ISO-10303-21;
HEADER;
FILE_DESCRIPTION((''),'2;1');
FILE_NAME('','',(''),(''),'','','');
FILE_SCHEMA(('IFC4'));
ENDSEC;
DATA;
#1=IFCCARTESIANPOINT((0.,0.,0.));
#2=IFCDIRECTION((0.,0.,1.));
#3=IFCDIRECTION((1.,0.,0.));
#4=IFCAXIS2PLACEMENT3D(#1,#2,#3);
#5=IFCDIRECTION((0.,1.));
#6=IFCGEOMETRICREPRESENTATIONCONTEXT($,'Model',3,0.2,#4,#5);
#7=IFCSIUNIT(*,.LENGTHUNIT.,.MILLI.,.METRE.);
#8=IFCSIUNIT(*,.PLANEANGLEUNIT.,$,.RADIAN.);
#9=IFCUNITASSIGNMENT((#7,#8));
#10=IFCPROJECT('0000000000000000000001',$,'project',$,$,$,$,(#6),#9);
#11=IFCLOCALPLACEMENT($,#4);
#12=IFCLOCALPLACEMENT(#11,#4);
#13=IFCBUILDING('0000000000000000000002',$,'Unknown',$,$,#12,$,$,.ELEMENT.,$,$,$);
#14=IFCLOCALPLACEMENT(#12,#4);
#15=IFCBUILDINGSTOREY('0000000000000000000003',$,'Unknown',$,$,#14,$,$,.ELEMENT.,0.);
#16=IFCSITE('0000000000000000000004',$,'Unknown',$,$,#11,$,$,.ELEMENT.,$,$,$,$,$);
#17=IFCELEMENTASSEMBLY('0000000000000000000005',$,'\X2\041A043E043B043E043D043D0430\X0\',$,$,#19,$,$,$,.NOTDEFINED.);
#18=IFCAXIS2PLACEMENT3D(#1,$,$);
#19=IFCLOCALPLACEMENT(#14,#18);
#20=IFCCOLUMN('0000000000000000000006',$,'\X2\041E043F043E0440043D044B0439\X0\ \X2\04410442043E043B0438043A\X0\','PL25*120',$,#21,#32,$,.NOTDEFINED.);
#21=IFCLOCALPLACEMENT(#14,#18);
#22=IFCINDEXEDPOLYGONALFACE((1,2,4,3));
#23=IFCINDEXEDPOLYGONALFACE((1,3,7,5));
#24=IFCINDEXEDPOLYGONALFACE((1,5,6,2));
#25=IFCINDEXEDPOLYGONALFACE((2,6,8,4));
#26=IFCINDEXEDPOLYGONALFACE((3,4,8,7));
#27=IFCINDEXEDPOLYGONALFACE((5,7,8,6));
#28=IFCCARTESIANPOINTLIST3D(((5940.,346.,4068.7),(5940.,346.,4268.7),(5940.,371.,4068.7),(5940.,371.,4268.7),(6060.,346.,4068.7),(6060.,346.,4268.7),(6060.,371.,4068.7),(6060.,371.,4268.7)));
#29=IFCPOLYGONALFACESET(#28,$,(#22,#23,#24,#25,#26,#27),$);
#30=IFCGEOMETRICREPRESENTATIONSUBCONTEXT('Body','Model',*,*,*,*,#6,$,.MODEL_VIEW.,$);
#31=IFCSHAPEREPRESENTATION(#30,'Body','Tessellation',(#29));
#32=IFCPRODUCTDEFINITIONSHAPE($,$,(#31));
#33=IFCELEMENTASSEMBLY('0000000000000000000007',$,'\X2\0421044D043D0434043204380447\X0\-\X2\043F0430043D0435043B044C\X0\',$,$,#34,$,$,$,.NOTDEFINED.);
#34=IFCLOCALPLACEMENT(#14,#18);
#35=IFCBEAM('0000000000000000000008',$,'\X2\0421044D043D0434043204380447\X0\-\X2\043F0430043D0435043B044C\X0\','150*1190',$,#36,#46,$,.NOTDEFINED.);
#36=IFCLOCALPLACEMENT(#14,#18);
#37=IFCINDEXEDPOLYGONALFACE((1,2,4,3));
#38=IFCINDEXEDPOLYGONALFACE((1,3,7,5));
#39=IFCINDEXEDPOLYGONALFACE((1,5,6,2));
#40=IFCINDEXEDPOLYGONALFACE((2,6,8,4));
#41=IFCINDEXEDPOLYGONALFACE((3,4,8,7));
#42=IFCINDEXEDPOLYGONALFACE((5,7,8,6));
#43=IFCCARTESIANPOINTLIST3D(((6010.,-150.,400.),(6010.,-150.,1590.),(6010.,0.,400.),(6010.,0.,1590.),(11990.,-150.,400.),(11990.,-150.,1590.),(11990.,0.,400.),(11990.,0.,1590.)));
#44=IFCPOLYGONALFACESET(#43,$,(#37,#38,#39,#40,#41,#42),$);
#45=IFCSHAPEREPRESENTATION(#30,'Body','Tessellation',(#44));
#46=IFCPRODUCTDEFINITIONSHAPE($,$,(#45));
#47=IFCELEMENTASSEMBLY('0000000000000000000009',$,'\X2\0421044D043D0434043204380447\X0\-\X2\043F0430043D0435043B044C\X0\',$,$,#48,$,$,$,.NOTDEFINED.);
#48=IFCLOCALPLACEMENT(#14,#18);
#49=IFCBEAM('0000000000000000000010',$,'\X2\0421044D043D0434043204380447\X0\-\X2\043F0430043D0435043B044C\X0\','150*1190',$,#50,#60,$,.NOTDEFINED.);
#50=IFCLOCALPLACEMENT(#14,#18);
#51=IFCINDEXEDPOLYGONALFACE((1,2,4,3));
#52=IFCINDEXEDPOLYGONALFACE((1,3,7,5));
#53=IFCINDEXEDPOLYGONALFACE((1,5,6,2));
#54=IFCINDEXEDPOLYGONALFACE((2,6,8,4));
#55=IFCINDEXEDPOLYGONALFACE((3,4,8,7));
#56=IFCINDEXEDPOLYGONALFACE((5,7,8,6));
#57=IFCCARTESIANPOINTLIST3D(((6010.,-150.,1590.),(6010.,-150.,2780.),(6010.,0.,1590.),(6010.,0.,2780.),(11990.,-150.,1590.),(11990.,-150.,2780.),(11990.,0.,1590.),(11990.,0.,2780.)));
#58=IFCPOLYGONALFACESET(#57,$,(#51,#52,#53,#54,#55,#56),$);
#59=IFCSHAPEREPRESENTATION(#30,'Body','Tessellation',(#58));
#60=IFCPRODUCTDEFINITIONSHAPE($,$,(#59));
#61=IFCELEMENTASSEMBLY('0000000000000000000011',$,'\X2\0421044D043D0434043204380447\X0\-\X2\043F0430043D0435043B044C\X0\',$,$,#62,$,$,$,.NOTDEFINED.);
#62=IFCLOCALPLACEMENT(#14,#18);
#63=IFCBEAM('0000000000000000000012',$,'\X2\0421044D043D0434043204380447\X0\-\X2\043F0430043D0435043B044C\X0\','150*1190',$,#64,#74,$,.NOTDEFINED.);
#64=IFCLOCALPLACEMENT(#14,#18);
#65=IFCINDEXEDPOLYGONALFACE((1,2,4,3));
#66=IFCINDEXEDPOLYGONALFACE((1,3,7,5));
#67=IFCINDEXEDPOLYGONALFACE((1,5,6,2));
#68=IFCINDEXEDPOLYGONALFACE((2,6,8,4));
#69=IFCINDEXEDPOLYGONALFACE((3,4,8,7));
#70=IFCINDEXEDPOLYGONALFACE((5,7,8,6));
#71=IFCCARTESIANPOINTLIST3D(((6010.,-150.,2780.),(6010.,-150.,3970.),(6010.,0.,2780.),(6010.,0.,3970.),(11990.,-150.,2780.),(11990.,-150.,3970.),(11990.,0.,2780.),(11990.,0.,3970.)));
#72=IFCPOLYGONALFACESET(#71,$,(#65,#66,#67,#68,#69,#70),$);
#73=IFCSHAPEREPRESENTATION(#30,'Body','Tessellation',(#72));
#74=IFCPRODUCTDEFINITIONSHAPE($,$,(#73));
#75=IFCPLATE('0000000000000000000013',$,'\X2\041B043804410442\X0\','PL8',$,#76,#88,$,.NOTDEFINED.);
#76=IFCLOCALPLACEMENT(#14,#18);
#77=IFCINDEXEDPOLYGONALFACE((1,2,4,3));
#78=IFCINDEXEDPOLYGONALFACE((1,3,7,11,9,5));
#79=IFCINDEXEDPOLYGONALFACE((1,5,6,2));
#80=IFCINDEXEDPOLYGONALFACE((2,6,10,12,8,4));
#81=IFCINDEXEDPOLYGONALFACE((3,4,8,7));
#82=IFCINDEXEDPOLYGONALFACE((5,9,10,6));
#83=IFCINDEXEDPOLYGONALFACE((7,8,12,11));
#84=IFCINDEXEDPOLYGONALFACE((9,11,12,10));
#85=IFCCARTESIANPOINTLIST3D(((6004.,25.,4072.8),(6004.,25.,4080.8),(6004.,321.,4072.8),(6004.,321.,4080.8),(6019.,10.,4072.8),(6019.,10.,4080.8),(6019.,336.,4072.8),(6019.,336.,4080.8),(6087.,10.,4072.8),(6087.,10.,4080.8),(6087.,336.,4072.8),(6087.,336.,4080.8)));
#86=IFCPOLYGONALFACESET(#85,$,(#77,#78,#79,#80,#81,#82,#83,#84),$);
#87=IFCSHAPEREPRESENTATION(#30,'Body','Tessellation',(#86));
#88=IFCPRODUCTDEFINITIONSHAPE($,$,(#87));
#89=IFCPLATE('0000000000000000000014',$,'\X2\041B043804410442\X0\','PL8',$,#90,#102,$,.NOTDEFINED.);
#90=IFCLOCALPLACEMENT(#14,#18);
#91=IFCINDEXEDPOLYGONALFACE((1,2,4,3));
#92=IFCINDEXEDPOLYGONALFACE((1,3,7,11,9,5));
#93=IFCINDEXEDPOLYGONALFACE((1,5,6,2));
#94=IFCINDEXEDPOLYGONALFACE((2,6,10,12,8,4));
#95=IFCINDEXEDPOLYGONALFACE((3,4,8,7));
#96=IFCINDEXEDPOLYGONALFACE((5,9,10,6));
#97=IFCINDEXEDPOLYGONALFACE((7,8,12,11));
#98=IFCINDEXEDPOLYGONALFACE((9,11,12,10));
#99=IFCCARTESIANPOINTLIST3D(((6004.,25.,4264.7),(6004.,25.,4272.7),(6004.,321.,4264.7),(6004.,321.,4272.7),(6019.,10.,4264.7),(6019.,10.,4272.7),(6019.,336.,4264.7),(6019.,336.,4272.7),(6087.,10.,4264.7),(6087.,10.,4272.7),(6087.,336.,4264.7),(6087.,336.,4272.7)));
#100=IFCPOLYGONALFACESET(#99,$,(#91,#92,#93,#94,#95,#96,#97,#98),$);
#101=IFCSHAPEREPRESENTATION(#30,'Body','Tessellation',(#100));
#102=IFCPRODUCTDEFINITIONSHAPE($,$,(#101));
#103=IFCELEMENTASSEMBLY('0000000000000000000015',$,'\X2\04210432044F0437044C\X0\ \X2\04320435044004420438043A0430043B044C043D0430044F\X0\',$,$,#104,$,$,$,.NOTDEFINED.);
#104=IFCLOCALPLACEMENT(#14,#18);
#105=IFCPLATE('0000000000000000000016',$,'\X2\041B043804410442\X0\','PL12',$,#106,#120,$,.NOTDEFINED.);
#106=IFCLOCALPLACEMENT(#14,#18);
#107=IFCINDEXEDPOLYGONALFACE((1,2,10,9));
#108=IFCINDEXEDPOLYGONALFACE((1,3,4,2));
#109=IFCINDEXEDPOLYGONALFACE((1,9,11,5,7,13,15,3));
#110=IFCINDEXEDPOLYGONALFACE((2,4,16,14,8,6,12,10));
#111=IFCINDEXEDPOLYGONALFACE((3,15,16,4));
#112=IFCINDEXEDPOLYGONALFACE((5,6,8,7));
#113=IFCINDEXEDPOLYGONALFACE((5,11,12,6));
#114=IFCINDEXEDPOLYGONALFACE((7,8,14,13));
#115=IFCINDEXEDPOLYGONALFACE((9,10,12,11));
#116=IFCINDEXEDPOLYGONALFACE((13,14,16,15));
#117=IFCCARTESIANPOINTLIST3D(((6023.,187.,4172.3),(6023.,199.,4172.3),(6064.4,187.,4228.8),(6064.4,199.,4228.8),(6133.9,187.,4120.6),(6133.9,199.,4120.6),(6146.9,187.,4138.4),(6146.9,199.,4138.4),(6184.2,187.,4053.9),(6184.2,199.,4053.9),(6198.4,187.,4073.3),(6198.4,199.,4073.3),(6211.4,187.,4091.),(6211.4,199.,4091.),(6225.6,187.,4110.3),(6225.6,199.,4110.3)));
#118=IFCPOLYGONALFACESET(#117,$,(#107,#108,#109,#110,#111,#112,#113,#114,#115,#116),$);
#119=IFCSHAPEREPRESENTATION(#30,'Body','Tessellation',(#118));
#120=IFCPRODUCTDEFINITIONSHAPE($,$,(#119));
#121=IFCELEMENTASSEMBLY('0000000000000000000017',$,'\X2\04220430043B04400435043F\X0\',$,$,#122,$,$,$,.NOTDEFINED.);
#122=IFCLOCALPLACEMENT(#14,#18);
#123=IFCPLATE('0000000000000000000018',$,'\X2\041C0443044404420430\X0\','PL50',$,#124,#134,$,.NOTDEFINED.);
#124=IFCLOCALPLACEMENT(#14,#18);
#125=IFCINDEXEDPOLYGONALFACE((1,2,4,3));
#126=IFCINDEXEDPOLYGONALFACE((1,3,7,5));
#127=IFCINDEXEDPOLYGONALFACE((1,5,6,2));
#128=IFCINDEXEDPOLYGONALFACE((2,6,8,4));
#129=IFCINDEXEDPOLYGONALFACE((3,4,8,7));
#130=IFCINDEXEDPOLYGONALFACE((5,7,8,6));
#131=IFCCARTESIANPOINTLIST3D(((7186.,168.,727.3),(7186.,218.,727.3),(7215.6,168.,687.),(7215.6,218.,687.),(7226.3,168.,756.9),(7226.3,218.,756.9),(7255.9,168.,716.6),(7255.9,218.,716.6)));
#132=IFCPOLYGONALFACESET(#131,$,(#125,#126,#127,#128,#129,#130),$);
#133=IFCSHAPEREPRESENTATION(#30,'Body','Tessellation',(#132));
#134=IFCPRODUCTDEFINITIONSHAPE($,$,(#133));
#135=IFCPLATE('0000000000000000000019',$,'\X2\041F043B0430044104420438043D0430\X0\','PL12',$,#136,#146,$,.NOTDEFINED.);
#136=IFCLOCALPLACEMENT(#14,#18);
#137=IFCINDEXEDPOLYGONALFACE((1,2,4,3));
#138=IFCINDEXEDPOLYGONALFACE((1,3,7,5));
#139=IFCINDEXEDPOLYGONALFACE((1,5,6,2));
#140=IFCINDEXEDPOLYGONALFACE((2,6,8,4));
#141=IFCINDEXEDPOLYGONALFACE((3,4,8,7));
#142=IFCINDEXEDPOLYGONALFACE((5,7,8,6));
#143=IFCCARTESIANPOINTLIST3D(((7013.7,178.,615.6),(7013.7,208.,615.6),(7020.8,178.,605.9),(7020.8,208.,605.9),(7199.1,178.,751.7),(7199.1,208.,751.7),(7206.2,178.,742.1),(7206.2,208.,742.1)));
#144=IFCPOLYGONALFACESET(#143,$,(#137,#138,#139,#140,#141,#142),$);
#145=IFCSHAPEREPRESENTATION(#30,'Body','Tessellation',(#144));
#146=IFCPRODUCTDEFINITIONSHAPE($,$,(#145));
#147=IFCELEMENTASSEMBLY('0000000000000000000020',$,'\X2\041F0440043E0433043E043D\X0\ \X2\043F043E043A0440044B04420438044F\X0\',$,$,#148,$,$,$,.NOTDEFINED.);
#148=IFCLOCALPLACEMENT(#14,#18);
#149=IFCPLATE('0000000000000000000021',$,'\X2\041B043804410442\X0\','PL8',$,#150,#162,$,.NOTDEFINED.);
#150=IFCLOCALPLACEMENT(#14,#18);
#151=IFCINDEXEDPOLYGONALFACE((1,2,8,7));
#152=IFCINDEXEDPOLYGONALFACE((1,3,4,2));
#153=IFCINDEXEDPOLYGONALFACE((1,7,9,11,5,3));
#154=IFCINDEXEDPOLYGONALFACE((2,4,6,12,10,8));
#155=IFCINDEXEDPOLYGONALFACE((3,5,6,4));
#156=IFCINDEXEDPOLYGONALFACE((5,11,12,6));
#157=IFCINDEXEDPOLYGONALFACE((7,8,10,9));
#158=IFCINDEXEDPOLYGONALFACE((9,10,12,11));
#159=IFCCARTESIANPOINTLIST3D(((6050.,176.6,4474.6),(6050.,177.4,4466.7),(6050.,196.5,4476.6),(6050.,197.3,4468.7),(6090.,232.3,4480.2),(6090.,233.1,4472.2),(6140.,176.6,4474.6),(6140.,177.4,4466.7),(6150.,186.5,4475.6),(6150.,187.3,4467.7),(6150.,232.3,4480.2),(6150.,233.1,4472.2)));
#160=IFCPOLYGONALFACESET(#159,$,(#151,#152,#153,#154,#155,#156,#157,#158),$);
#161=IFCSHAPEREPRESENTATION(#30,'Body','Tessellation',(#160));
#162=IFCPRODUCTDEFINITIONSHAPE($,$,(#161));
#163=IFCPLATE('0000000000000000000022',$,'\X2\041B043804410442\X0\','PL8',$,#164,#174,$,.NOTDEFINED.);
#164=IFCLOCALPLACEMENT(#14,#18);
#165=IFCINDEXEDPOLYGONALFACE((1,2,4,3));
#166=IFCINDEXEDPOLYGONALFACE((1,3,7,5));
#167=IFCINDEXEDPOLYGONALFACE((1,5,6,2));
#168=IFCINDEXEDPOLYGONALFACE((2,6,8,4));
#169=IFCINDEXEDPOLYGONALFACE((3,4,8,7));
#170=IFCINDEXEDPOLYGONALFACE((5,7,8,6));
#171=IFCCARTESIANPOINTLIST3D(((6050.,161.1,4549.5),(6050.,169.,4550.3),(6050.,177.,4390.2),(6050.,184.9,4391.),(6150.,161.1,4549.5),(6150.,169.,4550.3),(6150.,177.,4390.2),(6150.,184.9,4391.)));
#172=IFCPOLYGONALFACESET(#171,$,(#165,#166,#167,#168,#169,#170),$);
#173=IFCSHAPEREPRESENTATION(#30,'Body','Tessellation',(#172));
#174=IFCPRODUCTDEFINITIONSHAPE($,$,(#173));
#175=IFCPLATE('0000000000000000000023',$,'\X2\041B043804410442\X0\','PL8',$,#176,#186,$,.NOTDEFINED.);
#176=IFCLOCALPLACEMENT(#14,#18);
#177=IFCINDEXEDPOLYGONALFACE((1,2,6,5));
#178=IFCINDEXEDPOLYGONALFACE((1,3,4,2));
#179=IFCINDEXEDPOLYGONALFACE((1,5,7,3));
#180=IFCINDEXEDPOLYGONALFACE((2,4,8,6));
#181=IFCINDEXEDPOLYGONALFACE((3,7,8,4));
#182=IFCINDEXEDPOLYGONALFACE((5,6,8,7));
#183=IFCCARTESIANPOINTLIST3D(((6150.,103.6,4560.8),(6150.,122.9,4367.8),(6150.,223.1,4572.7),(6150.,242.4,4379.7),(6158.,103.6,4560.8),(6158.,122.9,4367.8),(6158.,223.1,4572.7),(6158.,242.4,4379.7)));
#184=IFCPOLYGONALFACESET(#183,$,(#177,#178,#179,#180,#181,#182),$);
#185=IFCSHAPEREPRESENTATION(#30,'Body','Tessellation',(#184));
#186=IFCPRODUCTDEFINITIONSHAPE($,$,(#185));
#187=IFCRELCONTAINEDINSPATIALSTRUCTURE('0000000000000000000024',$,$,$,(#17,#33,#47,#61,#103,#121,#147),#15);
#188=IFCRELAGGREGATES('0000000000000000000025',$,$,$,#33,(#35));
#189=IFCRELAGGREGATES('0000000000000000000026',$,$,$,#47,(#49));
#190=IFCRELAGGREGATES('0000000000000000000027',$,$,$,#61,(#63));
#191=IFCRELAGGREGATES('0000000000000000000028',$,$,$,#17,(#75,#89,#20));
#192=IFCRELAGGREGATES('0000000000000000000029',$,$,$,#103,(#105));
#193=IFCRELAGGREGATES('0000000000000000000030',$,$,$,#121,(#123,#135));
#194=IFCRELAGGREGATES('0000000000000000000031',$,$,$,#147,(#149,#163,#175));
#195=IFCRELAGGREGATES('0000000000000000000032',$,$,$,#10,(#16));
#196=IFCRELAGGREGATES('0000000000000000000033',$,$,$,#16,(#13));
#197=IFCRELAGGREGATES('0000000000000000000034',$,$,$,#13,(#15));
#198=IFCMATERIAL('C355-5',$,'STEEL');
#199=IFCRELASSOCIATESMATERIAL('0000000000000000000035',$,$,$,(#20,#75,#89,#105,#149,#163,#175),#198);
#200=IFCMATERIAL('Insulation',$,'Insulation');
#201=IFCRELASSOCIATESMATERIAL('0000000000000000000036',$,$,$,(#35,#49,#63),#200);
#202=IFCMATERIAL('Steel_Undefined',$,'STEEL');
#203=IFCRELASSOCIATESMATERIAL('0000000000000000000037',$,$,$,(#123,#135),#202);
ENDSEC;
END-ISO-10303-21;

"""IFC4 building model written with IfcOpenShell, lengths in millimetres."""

from ifc_helpers import new_model, si_unit, direction, frame, origin_with_axes, place, context, subcontext, project, spatial, line, indexed_curve, outline, extrude, material, element, aggregate, save


model = new_model("IFC4")

# Units and contexts
model_context = context("Model", 3, precision=0.2, world=origin_with_axes(), true_north=direction((0.0, 1.0)))
body_context = subcontext(model_context, "Body", "Model", "MODEL_VIEW")
ifc_project = project(units=[si_unit("LENGTHUNIT", "METRE", prefix="MILLI"), si_unit("PLANEANGLEUNIT", "RADIAN")], contexts=[model_context])

# Site, building, storey
site_placement = place(None, origin_with_axes())
site = spatial("IfcSite", under=ifc_project, at=site_placement, Name="Unknown", CompositionType="ELEMENT")
building_placement = place(site_placement, origin_with_axes())
building = spatial("IfcBuilding", under=site, at=building_placement, Name="Unknown", CompositionType="ELEMENT")
storey_placement = place(building_placement, origin_with_axes())
storey = spatial("IfcBuildingStorey", under=building, at=storey_placement, Name="Unknown", CompositionType="ELEMENT", Elevation=0.0)

# Element assembly, column
assembly_1_placement = place(storey_placement, frame((6000.0, 173.0, -200.0), z_axis=(-1.0, 0.0, 0.0), x_axis=(0.0, 0.0, 1.0)))
assembly_1 = element("IfcElementAssembly", 1, at=assembly_1_placement, inside=storey, Name="Колонна", PredefinedType="NOTDEFINED")
ifc_material_1 = material(Name="C355-5", Category="STEEL")
column_1_placement = place(assembly_1_placement, frame((4268.7, 185.5, 0.0), z_axis=(0.0, 1.0, 0.0), x_axis=(1.0, 0.0, 0.0)))
column_1 = element("IfcColumn", 2, at=column_1_placement, material=ifc_material_1, Name="Опорный столик", Description="PL25*120", PredefinedType="NOTDEFINED", context=body_context, shape_type="SolidModel", body=[
    extrude(outline(indexed_curve([(-12.5, -60.0), (12.5, -60.0), (12.5, 60.0), (-12.5, 60.0)], segments=[line(1, 2, 3, 4, 1)])), frame((0.0, 0.0, 0.0), z_axis=(-1.0, 0.0, 0.0), x_axis=(0.0, 0.0, 1.0)), (0.0, 0.0, -1.0), 200.0),
])

# Element assemblies, beams
ifc_material_2 = material(Name="Insulation", Category="Insulation")
assembly_2_placement = place(storey_placement, frame((6010.0, -75.0, 995.0), z_axis=(0.0, 0.0, -1.0), x_axis=(1.0, 0.0, 0.0)))
assembly_2 = element("IfcElementAssembly", 3, at=assembly_2_placement, inside=storey, Name="Сэндвич-панель", PredefinedType="NOTDEFINED")
beam_1_placement = place(assembly_2_placement, origin_with_axes())
beam_1 = element("IfcBeam", 4, at=beam_1_placement, material=ifc_material_2, Name="Сэндвич-панель", Description="150*1190", PredefinedType="NOTDEFINED", context=body_context, shape_type="SolidModel", body=[
    extrude(outline(indexed_curve([(-595.0, -75.0), (595.0, -75.0), (595.0, 75.0), (-595.0, 75.0)], segments=[line(1, 2, 3, 4, 1)])), frame((0.0, 0.0, 0.0), z_axis=(-1.0, 0.0, 0.0), x_axis=(0.0, 0.0, 1.0)), (0.0, 0.0, -1.0), 5980.0),
])
aggregate(assembly_2, [beam_1])
assembly_3_placement = place(storey_placement, frame((6010.0, -75.0, 2185.0), z_axis=(0.0, 0.0, -1.0), x_axis=(1.0, 0.0, 0.0)))
assembly_3 = element("IfcElementAssembly", 5, at=assembly_3_placement, inside=storey, Name="Сэндвич-панель", PredefinedType="NOTDEFINED")
beam_2_placement = place(assembly_3_placement, origin_with_axes())
beam_2 = element("IfcBeam", 6, at=beam_2_placement, material=ifc_material_2, Name="Сэндвич-панель", Description="150*1190", PredefinedType="NOTDEFINED", context=body_context, shape_type="SolidModel", body=[
    extrude(outline(indexed_curve([(-595.0, -75.0), (595.0, -75.0), (595.0, 75.0), (-595.0, 75.0)], segments=[line(1, 2, 3, 4, 1)])), frame((0.0, 0.0, 0.0), z_axis=(-1.0, 0.0, 0.0), x_axis=(0.0, 0.0, 1.0)), (0.0, 0.0, -1.0), 5980.0),
])
aggregate(assembly_3, [beam_2])
assembly_4_placement = place(storey_placement, frame((6010.0, -75.0, 3375.0), z_axis=(0.0, 0.0, -1.0), x_axis=(1.0, 0.0, 0.0)))
assembly_4 = element("IfcElementAssembly", 7, at=assembly_4_placement, inside=storey, Name="Сэндвич-панель", PredefinedType="NOTDEFINED")
beam_3_placement = place(assembly_4_placement, origin_with_axes())
beam_3 = element("IfcBeam", 8, at=beam_3_placement, material=ifc_material_2, Name="Сэндвич-панель", Description="150*1190", PredefinedType="NOTDEFINED", context=body_context, shape_type="SolidModel", body=[
    extrude(outline(indexed_curve([(-595.0, -75.0), (595.0, -75.0), (595.0, 75.0), (-595.0, 75.0)], segments=[line(1, 2, 3, 4, 1)])), frame((0.0, 0.0, 0.0), z_axis=(-1.0, 0.0, 0.0), x_axis=(0.0, 0.0, 1.0)), (0.0, 0.0, -1.0), 5980.0),
])
aggregate(assembly_4, [beam_3])

# Plates
plate_1_placement = place(assembly_1_placement, frame((4276.8, -163.0, -87.0), z_axis=(-1.0, 0.0, 0.0), x_axis=(0.0, 0.0, 1.0)))
plate_1 = element("IfcPlate", 9, at=plate_1_placement, material=ifc_material_1, Name="Лист", Description="PL8", PredefinedType="NOTDEFINED", context=body_context, shape_type="SolidModel", body=[
    extrude(outline(indexed_curve([(0.0, 0.0), (68.0, 0.0), (83.0, 15.0), (83.0, 311.0), (68.0, 326.0), (0.0, 326.0)], segments=[line(1, 2, 3, 4, 5, 6, 1)])), frame((0.0, 0.0, 4.0), z_axis=(0.0, 0.0, 1.0), x_axis=(1.0, 0.0, 0.0)), (0.0, 0.0, -1.0), 8.0),
])
plate_2_placement = place(assembly_1_placement, frame((4468.7, -163.0, -87.0), z_axis=(-1.0, 0.0, 0.0), x_axis=(0.0, 0.0, 1.0)))
plate_2 = element("IfcPlate", 10, at=plate_2_placement, material=ifc_material_1, Name="Лист", Description="PL8", PredefinedType="NOTDEFINED", context=body_context, shape_type="SolidModel", body=[
    extrude(outline(indexed_curve([(0.0, 0.0), (68.0, 0.0), (83.0, 15.0), (83.0, 311.0), (68.0, 326.0), (0.0, 326.0)], segments=[line(1, 2, 3, 4, 5, 6, 1)])), frame((0.0, 0.0, 4.0), z_axis=(0.0, 0.0, 1.0), x_axis=(1.0, 0.0, 0.0)), (0.0, 0.0, -1.0), 8.0),
])
aggregate(assembly_1, [plate_1, plate_2, column_1])

# Element assembly, plate
assembly_5_placement = place(storey_placement, frame((6087.0, 193.0, 4168.8), z_axis=(0.0, -1.0, 0.0), x_axis=(0.805914, 0.0, -0.592033)))
assembly_5 = element("IfcElementAssembly", 11, at=assembly_5_placement, inside=storey, Name="Связь вертикальная", PredefinedType="NOTDEFINED")
plate_3_placement = place(assembly_5_placement, frame((146.3, -35.0, 0.0), z_axis=(0.0, 0.0, -1.0), x_axis=(-1.0, 0.0, 0.0)))
plate_3 = element("IfcPlate", 12, at=plate_3_placement, material=ifc_material_1, Name="Лист", Description="PL12", PredefinedType="NOTDEFINED", context=body_context, shape_type="SolidModel", body=[
    extrude(outline(indexed_curve([(0.0, 0.0), (200.0, 0.0), (200.0, 70.0), (0.0, 70.0), (0.0, 46.0), (80.0, 46.0), (80.0, 24.0), (0.0, 24.0)], segments=[line(1, 2, 3, 4, 5, 6, 7, 8, 1)])), frame((0.0, 0.0, 6.0), z_axis=(0.0, 0.0, 1.0), x_axis=(1.0, 0.0, 0.0)), (0.0, 0.0, -1.0), 12.0),
])
aggregate(assembly_5, [plate_3])

# Element assemblies, plates
assembly_6_placement = place(storey_placement, frame((7206.2, 168.0, 742.1), z_axis=(-0.805914, 0.0, -0.592033), x_axis=(0.0, 1.0, 0.0)))
assembly_6 = element("IfcElementAssembly", 13, at=assembly_6_placement, inside=storey, Name="Талреп", PredefinedType="NOTDEFINED")
ifc_material_3 = material(Name="Steel_Undefined", Category="STEEL")
plate_4_placement = place(assembly_6_placement, origin_with_axes())
plate_4 = element("IfcPlate", 14, at=plate_4_placement, material=ifc_material_3, Name="Муфта", Description="PL50", PredefinedType="NOTDEFINED", context=body_context, shape_type="SolidModel", body=[
    extrude(outline(indexed_curve([(0.0, 0.0), (50.0, 0.0), (50.0, 50.0), (0.0, 50.0)], segments=[line(1, 2, 3, 4, 1)])), frame((0.0, 0.0, 25.0), z_axis=(0.0, 0.0, 1.0), x_axis=(1.0, 0.0, 0.0)), (0.0, 0.0, -1.0), 50.0),
])
plate_5_placement = place(assembly_6_placement, frame((10.0, -6.0, 230.0), z_axis=(0.0, 1.0, 0.0), x_axis=(1.0, 0.0, 0.0)))
plate_5 = element("IfcPlate", 15, at=plate_5_placement, material=ifc_material_3, Name="Пластина", Description="PL12", PredefinedType="NOTDEFINED", context=body_context, shape_type="SolidModel", body=[
    extrude(outline(indexed_curve([(0.0, 0.0), (30.0, 0.0), (30.0, 230.0), (0.0, 230.0)], segments=[line(1, 2, 3, 4, 1)])), frame((0.0, 0.0, 6.0), z_axis=(0.0, 0.0, 1.0), x_axis=(1.0, 0.0, 0.0)), (0.0, 0.0, -1.0), 12.0),
])
aggregate(assembly_6, [plate_4, plate_5])
assembly_7_placement = place(storey_placement, frame((6000.0, 173.0, 4470.2), z_axis=(0.0, 0.995037, 0.099504), x_axis=(1.0, 0.0, 0.0)))
assembly_7 = element("IfcElementAssembly", 16, at=assembly_7_placement, inside=storey, Name="Прогон покрытия", PredefinedType="NOTDEFINED")
plate_6_placement = place(assembly_7_placement, frame((50.0, 0.0, 60.0), z_axis=(0.0, -1.0, 0.0), x_axis=(0.0, 0.0, -1.0)))
plate_6 = element("IfcPlate", 17, at=plate_6_placement, material=ifc_material_1, Name="Лист", Description="PL8", PredefinedType="NOTDEFINED", context=body_context, shape_type="SolidModel", body=[
    extrude(outline(indexed_curve([(0.0, 40.0), (36.0, 0.0), (56.0, 0.0), (56.0, 90.0), (46.0, 100.0), (0.0, 100.0)], segments=[line(1, 2, 3, 4, 5, 6, 1)])), frame((0.0, 0.0, 4.0), z_axis=(0.0, 0.0, 1.0), x_axis=(1.0, 0.0, 0.0)), (0.0, 0.0, -1.0), 8.0),
])
plate_7_placement = place(assembly_7_placement, frame((50.0, -80.0, 0.0), z_axis=(0.0, 0.0, -1.0), x_axis=(0.0, 1.0, 0.0)))
plate_7 = element("IfcPlate", 18, at=plate_7_placement, material=ifc_material_1, Name="Лист", Description="PL8", PredefinedType="NOTDEFINED", context=body_context, shape_type="SolidModel", body=[
    extrude(outline(indexed_curve([(0.0, 0.0), (160.0, 0.0), (160.0, 100.0), (0.0, 100.0)], segments=[line(1, 2, 3, 4, 1)])), frame((0.0, 0.0, 4.0), z_axis=(0.0, 0.0, 1.0), x_axis=(1.0, 0.0, 0.0)), (0.0, 0.0, -1.0), 8.0),
])
plate_8_placement = place(assembly_7_placement, frame((154.0, -97.0, -60.0), z_axis=(-1.0, 0.0, 0.0), x_axis=(0.0, 0.0, 1.0)))
plate_8 = element("IfcPlate", 19, at=plate_8_placement, material=ifc_material_1, Name="Лист", Description="PL8", PredefinedType="NOTDEFINED", context=body_context, shape_type="SolidModel", body=[
    extrude(outline(indexed_curve([(0.0, 0.0), (120.0, 0.0), (120.0, 194.0), (0.0, 194.0)], segments=[line(1, 2, 3, 4, 1)])), frame((0.0, 0.0, 4.0), z_axis=(0.0, 0.0, 1.0), x_axis=(1.0, 0.0, 0.0)), (0.0, 0.0, -1.0), 8.0),
])
aggregate(assembly_7, [plate_6, plate_7, plate_8])

save(model, "model.ifc")
